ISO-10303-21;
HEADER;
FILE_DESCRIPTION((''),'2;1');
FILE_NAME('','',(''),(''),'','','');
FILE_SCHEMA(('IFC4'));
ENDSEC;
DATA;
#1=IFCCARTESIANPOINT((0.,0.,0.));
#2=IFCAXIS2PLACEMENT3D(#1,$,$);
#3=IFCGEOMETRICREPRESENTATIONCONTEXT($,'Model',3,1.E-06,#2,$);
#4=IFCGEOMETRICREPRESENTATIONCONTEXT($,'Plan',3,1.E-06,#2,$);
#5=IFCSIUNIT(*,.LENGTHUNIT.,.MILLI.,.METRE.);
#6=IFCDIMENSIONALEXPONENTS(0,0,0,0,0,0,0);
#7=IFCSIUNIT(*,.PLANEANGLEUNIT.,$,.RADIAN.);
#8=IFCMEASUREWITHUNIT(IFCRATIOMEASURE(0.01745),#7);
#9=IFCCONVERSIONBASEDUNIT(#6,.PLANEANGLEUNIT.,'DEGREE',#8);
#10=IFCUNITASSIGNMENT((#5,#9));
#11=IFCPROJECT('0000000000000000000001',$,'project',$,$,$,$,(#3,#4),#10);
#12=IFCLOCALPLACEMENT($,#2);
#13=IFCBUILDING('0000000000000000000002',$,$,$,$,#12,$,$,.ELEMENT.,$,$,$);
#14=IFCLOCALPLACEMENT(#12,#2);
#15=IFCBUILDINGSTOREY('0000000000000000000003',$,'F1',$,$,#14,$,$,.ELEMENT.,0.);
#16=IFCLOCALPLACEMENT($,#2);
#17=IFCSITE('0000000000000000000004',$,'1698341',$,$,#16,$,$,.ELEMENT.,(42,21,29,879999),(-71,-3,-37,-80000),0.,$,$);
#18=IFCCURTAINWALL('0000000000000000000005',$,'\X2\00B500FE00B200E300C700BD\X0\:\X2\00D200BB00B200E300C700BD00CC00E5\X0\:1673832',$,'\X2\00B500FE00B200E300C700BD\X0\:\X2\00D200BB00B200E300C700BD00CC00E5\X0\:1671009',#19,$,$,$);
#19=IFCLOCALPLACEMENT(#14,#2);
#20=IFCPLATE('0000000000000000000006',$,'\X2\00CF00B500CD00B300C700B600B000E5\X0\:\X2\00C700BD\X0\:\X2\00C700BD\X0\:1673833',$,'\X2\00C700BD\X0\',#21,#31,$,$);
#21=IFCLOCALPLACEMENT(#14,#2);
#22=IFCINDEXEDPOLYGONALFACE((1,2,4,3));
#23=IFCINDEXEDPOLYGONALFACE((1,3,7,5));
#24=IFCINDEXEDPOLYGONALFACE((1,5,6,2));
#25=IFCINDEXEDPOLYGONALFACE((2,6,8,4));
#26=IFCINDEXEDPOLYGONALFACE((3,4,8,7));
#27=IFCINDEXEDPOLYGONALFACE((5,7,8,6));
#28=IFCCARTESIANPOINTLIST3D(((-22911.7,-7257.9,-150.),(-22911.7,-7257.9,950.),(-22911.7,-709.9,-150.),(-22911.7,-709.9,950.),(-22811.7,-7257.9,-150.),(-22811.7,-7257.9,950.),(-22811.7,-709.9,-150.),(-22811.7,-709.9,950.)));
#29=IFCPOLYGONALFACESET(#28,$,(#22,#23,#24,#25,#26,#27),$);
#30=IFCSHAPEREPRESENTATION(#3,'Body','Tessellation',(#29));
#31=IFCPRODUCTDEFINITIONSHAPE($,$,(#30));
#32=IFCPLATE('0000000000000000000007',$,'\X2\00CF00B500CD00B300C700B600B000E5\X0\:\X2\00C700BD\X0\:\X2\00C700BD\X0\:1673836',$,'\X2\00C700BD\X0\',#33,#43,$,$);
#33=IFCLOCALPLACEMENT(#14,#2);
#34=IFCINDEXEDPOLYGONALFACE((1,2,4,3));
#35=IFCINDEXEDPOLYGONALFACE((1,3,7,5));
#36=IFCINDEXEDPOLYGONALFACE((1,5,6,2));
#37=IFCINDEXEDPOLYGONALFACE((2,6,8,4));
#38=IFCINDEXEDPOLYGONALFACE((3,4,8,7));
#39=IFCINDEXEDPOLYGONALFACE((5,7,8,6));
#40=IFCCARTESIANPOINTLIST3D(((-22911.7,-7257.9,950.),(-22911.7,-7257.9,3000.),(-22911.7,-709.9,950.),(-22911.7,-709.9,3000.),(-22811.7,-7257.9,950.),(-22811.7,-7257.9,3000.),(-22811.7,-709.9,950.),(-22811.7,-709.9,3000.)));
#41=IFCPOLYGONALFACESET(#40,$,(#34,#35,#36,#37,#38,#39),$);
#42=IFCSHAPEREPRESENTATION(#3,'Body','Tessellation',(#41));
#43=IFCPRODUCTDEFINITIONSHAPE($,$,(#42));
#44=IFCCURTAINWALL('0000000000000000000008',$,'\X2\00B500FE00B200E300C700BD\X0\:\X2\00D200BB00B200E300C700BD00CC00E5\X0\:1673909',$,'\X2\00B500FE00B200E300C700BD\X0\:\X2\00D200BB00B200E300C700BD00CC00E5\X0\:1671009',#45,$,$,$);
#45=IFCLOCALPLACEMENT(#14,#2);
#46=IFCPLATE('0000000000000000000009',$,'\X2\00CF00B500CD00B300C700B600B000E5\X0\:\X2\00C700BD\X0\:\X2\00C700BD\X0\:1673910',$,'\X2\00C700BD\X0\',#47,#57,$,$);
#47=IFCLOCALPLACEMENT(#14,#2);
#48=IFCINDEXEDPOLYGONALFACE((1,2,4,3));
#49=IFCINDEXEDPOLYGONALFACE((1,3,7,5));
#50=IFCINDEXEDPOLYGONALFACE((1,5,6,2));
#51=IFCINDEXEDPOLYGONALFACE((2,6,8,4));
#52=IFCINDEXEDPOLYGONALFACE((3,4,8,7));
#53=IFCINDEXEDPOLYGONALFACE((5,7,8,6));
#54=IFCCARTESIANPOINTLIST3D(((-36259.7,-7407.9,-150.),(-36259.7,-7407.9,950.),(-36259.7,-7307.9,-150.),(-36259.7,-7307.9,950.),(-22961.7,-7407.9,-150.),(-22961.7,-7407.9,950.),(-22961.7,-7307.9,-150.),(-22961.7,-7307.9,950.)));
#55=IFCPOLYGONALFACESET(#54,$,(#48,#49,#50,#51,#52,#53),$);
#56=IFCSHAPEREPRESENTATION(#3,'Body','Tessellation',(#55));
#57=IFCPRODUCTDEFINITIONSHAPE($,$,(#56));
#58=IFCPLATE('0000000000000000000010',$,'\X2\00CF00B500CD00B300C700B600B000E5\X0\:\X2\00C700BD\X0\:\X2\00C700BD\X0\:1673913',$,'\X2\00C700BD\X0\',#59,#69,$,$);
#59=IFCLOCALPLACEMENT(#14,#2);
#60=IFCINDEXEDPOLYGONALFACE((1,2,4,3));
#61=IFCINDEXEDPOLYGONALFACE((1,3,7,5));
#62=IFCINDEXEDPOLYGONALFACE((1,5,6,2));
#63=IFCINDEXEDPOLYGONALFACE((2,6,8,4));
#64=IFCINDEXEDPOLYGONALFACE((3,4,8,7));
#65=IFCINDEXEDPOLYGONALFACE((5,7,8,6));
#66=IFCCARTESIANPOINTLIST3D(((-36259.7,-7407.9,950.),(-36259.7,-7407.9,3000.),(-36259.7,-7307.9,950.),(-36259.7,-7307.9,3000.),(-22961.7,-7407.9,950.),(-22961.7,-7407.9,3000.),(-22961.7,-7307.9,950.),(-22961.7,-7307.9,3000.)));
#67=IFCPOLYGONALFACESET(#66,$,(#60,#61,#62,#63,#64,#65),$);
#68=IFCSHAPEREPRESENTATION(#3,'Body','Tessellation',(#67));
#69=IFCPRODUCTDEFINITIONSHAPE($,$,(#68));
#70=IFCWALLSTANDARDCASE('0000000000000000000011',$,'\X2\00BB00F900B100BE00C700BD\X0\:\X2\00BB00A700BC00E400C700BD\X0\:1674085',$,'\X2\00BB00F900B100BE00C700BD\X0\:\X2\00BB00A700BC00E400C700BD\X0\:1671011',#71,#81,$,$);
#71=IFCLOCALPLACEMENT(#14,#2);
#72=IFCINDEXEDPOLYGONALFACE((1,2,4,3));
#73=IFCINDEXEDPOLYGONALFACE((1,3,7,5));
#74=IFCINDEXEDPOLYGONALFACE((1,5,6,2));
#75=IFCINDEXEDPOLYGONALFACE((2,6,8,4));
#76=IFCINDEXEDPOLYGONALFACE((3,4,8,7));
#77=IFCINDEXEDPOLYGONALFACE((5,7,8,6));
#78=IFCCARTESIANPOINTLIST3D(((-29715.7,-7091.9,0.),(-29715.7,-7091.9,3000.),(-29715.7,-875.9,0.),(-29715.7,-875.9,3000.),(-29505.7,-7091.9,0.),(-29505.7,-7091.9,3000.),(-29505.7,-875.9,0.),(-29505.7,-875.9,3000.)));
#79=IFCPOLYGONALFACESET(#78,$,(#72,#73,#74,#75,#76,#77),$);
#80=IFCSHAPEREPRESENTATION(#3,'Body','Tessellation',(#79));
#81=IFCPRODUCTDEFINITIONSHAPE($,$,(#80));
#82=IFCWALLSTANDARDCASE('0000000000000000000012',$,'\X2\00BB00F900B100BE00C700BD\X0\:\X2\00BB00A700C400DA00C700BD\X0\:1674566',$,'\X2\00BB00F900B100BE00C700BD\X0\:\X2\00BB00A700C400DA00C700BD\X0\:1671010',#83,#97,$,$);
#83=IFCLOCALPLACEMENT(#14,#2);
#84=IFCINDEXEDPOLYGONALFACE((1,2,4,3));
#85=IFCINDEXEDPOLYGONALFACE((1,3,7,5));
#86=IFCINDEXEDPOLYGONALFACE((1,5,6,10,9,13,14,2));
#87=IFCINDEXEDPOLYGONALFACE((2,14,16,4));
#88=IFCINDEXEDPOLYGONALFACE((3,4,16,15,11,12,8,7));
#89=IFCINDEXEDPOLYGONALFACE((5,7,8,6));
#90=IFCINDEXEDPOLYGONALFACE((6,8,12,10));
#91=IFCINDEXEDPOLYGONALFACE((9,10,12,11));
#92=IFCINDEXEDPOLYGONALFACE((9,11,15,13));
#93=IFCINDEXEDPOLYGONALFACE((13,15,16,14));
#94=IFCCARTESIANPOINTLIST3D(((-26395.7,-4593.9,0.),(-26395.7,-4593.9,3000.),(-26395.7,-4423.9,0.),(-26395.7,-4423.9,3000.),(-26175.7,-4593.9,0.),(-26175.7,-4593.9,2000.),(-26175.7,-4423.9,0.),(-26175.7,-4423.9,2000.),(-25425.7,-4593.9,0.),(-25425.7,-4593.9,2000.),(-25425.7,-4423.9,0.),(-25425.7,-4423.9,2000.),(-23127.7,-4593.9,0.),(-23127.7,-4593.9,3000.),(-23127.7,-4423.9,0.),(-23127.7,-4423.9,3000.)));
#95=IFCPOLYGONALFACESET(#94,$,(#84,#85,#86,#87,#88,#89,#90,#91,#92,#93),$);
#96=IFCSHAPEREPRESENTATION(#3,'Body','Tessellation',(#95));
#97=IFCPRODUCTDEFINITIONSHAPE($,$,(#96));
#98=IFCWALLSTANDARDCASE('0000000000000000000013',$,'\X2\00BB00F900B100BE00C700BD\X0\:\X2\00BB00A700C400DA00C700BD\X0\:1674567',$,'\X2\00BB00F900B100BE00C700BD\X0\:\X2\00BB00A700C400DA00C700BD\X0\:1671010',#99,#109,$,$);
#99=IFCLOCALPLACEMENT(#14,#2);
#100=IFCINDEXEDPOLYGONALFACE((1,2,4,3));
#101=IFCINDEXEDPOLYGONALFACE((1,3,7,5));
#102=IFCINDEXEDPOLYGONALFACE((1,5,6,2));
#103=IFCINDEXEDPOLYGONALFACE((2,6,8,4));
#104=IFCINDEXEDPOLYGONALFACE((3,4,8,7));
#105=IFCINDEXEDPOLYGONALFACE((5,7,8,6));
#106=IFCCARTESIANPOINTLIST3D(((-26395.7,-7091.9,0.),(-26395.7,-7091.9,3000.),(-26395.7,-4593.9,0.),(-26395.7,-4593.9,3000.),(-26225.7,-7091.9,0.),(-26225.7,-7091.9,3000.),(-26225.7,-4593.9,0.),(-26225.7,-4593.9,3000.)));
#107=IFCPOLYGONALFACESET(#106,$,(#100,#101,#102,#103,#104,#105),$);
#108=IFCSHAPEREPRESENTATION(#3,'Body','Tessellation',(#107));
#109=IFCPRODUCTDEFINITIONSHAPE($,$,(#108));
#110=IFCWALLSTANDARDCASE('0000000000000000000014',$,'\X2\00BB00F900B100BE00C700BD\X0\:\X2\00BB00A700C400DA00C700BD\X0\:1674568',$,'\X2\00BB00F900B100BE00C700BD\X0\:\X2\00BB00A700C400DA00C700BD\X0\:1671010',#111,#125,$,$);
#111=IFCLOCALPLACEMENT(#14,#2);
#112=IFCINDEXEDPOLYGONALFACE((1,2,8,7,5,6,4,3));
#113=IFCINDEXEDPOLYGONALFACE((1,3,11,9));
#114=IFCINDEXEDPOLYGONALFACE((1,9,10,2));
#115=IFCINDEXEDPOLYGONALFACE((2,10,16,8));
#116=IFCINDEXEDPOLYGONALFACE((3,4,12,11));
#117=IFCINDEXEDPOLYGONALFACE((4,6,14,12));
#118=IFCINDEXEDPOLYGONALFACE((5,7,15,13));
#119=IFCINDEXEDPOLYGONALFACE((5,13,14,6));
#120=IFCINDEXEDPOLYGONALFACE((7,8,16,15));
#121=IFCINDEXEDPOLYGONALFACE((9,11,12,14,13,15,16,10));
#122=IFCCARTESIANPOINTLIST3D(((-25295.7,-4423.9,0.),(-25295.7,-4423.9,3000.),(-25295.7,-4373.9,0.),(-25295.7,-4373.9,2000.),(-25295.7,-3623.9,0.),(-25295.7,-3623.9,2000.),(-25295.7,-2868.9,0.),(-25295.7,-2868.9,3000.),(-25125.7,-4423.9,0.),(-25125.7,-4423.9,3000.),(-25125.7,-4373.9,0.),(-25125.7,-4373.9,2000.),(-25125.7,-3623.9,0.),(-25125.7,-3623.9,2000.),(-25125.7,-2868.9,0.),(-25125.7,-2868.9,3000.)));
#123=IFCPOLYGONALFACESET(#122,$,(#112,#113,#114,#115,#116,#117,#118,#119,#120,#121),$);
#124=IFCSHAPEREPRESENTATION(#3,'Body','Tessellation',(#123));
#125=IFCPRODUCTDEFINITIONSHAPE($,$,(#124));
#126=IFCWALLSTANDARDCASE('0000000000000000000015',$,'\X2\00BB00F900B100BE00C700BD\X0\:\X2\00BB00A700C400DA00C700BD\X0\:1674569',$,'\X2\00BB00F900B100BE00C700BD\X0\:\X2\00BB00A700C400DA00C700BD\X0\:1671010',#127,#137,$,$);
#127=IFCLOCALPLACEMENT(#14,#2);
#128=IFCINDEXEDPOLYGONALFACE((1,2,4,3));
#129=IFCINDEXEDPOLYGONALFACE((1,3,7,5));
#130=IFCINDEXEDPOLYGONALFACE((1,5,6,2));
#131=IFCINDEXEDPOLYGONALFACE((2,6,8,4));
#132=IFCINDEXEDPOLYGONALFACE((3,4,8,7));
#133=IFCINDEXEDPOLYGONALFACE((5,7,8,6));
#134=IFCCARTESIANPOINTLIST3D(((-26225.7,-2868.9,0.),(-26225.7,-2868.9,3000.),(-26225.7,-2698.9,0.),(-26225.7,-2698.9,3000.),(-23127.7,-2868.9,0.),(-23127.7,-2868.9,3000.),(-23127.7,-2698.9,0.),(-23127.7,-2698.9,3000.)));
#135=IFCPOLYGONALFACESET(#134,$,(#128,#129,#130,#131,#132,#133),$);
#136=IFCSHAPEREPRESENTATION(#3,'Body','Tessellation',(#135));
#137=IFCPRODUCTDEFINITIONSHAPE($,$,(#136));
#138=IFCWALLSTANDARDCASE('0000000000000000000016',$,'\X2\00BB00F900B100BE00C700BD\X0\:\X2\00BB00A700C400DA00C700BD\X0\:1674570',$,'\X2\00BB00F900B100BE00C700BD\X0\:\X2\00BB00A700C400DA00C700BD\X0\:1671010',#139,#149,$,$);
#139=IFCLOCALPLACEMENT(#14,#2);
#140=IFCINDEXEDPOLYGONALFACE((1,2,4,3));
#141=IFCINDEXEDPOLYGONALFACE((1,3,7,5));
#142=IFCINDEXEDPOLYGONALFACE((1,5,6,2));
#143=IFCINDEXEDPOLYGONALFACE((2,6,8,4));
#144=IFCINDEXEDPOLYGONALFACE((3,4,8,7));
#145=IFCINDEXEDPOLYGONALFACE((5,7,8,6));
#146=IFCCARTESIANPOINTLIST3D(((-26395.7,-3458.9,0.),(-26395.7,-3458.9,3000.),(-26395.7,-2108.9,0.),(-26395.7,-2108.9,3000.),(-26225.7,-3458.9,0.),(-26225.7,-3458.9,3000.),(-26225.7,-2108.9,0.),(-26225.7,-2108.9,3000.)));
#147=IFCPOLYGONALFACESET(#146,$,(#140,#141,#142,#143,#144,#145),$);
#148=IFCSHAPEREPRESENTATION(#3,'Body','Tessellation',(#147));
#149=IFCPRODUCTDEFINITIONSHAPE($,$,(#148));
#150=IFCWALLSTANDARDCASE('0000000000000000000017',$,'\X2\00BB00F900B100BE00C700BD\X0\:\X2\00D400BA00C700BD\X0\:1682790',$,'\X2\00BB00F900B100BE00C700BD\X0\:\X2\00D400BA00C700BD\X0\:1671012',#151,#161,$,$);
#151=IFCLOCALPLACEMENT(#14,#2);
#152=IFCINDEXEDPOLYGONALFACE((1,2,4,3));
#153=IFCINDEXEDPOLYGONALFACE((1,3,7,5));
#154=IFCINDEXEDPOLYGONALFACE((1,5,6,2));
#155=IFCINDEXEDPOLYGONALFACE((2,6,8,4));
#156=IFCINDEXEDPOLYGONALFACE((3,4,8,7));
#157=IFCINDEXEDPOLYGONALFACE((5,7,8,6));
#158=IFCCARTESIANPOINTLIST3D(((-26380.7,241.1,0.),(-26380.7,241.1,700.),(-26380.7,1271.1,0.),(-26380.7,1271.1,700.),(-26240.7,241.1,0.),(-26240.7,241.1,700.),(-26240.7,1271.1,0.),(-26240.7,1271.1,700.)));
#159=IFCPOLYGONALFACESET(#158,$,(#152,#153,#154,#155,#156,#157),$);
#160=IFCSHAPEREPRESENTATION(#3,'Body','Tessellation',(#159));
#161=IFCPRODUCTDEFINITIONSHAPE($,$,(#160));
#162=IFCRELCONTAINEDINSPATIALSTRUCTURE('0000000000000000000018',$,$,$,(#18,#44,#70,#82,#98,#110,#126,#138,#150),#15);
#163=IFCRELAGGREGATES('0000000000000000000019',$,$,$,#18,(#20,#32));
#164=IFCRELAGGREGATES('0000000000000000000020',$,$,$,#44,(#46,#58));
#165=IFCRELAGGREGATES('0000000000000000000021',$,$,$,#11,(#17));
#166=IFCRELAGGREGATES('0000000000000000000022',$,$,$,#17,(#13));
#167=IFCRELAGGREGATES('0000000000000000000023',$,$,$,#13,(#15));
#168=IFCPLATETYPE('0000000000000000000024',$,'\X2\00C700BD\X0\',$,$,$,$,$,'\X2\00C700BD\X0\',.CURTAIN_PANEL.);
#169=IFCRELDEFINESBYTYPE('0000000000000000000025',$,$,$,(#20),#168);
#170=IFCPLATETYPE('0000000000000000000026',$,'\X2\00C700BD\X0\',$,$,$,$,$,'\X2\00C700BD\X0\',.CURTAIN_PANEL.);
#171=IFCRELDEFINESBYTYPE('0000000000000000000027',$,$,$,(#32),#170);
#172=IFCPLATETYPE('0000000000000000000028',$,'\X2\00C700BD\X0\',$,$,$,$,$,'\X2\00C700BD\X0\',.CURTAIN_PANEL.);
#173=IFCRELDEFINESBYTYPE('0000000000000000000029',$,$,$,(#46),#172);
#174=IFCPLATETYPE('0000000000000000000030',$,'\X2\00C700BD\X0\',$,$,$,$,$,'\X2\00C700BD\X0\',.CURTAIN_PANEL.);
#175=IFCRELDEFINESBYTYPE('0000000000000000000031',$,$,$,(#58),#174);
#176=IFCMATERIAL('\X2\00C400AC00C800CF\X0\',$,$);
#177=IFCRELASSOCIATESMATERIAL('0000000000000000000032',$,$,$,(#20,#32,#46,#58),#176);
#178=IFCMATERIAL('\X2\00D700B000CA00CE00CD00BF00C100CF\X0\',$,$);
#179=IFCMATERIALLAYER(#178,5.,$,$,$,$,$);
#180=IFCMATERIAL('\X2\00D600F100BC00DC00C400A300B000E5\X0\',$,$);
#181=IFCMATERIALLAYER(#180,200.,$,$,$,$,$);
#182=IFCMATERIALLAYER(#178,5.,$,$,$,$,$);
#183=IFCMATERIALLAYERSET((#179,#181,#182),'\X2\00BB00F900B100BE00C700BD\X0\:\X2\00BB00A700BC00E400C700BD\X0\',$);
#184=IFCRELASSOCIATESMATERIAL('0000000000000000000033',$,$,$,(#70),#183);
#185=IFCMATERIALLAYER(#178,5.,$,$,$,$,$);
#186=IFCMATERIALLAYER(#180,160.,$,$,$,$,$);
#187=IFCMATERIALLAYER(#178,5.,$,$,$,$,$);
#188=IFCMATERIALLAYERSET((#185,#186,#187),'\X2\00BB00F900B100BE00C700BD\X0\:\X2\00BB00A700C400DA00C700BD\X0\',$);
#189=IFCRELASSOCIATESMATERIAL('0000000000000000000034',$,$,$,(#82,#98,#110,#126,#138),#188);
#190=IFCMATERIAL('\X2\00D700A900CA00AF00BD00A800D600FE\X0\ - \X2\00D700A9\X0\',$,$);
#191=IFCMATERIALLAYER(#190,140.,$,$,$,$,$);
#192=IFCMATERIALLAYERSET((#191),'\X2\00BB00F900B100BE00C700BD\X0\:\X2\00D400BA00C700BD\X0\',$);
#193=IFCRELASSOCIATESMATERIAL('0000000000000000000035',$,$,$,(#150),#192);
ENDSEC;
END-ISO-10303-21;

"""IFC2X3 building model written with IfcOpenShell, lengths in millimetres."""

from ifc_helpers import new_model, entity, si_unit, converted_unit, frame, frame_2d, origin, origin_2d_with_axis, place, context, project, spatial, rectangle, extrude, source, transform, mapped, material, layer, layer_set, layer_usage, type_object, type_shapes, element, aggregate, save


model = new_model("IFC2X3")

# Units and contexts
model_context = context("Model", 3, precision=1e-06, world=origin())
plan_context = context("Plan", 3, precision=1e-06, world=origin())
ifc_project = project(units=[si_unit("LENGTHUNIT", "METRE", prefix="MILLI"), converted_unit("PLANEANGLEUNIT", "DEGREE", entity("IfcRatioMeasure", 0.01745), si_unit("PLANEANGLEUNIT", "RADIAN"), dimensions=[0, 0, 0, 0, 0, 0, 0])], contexts=[model_context, plan_context])

# Site, building, storey
site_placement = place(None, origin())
site = spatial("IfcSite", under=ifc_project, at=site_placement, Name="1698341", CompositionType="ELEMENT", RefLatitude=(42, 21, 29, 879999), RefLongitude=(-71, -3, -37, -80000), RefElevation=0.0)
building_placement = place(None, origin())
building = spatial("IfcBuilding", under=site, at=building_placement, CompositionType="ELEMENT")
storey_placement = place(building_placement, origin())
storey = spatial("IfcBuildingStorey", under=building, at=storey_placement, Name="F1", CompositionType="ELEMENT", Elevation=0.0)

# Curtain walls, plates
curtain_wall_1_placement = place(storey_placement, origin())
curtain_wall_1 = element("IfcCurtainWall", 1, at=curtain_wall_1_placement, inside=storey, Name="µþ²ãÇ½:Ò»²ãÇ½Ìå:1673832", ObjectType="µþ²ãÇ½:Ò»²ãÇ½Ìå:1671009")
ifc_material_1 = material(Name="Ä¬ÈÏ")
plate_type_1 = type_object("IfcPlateType", Name="Ç½", ElementType="Ç½", PredefinedType="CURTAIN_PANEL")
shared_shape_1 = source(origin(), model_context, "Body", "SweptSolid", [
    extrude(rectangle(XDim=100.0, YDim=6548.0, at=origin_2d_with_axis()), frame((0.0, 100.0, 0.0), z_axis=(0.0, 0.0, 1.0), x_axis=(0.0, 1.0, 0.0)), (0.0, 0.0, 1.0), 1100.0),
])
type_shapes(plate_type_1, [shared_shape_1])
plate_1_placement = place(None, frame((-22961.7, -3983.9, -150.0), z_axis=(0.0, 0.0, 1.0), x_axis=(0.0, -1.0, 0.0)))
plate_1 = element("IfcPlate", 2, at=plate_1_placement, type_object=plate_type_1, material=ifc_material_1, Name="ÏµÍ³Ç¶°å:Ç½:Ç½:1673833", ObjectType="Ç½", context=model_context, shape_type="MappedRepresentation", body=[
    mapped(shared_shape_1, transform((0.0, 0.0, 0.0), scale=1.0)),
])
plate_type_2 = type_object("IfcPlateType", Name="Ç½", ElementType="Ç½", PredefinedType="CURTAIN_PANEL")
shared_shape_2 = source(origin(), model_context, "Body", "SweptSolid", [
    extrude(rectangle(XDim=100.0, YDim=6548.0, at=origin_2d_with_axis()), frame((0.0, 100.0, 0.0), z_axis=(0.0, 0.0, 1.0), x_axis=(0.0, 1.0, 0.0)), (0.0, 0.0, 1.0), 2050.0),
])
type_shapes(plate_type_2, [shared_shape_2])
plate_2_placement = place(None, frame((-22961.7, -3983.9, 950.0), z_axis=(0.0, 0.0, 1.0), x_axis=(0.0, -1.0, 0.0)))
plate_2 = element("IfcPlate", 3, at=plate_2_placement, type_object=plate_type_2, material=ifc_material_1, Name="ÏµÍ³Ç¶°å:Ç½:Ç½:1673836", ObjectType="Ç½", context=model_context, shape_type="MappedRepresentation", body=[
    mapped(shared_shape_2, transform((0.0, 0.0, 0.0), scale=1.0)),
])
aggregate(curtain_wall_1, [plate_1, plate_2])
curtain_wall_2_placement = place(storey_placement, origin())
curtain_wall_2 = element("IfcCurtainWall", 4, at=curtain_wall_2_placement, inside=storey, Name="µþ²ãÇ½:Ò»²ãÇ½Ìå:1673909", ObjectType="µþ²ãÇ½:Ò»²ãÇ½Ìå:1671009")
plate_type_3 = type_object("IfcPlateType", Name="Ç½", ElementType="Ç½", PredefinedType="CURTAIN_PANEL")
shared_shape_3 = source(origin(), model_context, "Body", "SweptSolid", [
    extrude(rectangle(XDim=100.0, YDim=13298.0, at=origin_2d_with_axis()), frame((0.0, 100.0, 0.0), z_axis=(0.0, 0.0, 1.0), x_axis=(0.0, 1.0, 0.0)), (0.0, 0.0, 1.0), 1100.0),
])
type_shapes(plate_type_3, [shared_shape_3])
plate_3_placement = place(None, frame((-29610.7, -7257.9, -150.0), z_axis=(0.0, 0.0, 1.0), x_axis=(-1.0, 0.0, 0.0)))
plate_3 = element("IfcPlate", 5, at=plate_3_placement, type_object=plate_type_3, material=ifc_material_1, Name="ÏµÍ³Ç¶°å:Ç½:Ç½:1673910", ObjectType="Ç½", context=model_context, shape_type="MappedRepresentation", body=[
    mapped(shared_shape_3, transform((0.0, 0.0, 0.0), scale=1.0)),
])
plate_type_4 = type_object("IfcPlateType", Name="Ç½", ElementType="Ç½", PredefinedType="CURTAIN_PANEL")
shared_shape_4 = source(origin(), model_context, "Body", "SweptSolid", [
    extrude(rectangle(XDim=100.0, YDim=13298.0, at=origin_2d_with_axis()), frame((0.0, 100.0, 0.0), z_axis=(0.0, 0.0, 1.0), x_axis=(0.0, 1.0, 0.0)), (0.0, 0.0, 1.0), 2050.0),
])
type_shapes(plate_type_4, [shared_shape_4])
plate_4_placement = place(None, frame((-29610.7, -7257.9, 950.0), z_axis=(0.0, 0.0, 1.0), x_axis=(-1.0, 0.0, 0.0)))
plate_4 = element("IfcPlate", 6, at=plate_4_placement, type_object=plate_type_4, material=ifc_material_1, Name="ÏµÍ³Ç¶°å:Ç½:Ç½:1673913", ObjectType="Ç½", context=model_context, shape_type="MappedRepresentation", body=[
    mapped(shared_shape_4, transform((0.0, 0.0, 0.0), scale=1.0)),
])
aggregate(curtain_wall_2, [plate_3, plate_4])

# Shared definitions
ifc_material_2 = material(Name="Öñ¼ÜÄ£°å")
ifc_material_3 = material(Name="×°ÊÎÍ¿ÁÏ")

# Wall
ifc_layer_1 = layer(ifc_material_3, 5.0)
ifc_layer_2 = layer(ifc_material_2, 200.0)
ifc_layer_3 = layer(ifc_material_3, 5.0)
ifc_layer_set_1 = layer_set([ifc_layer_1, ifc_layer_2, ifc_layer_3], Name="»ù±¾Ç½:»§¼äÇ½")
ifc_layer_usage_1 = layer_usage(ifc_layer_set_1, "AXIS2", "NEGATIVE", 105.0)
wall_1_placement = place(storey_placement, frame((-29610.7, -7091.9, 0.0), z_axis=(0.0, 0.0, 1.0), x_axis=(0.0, 1.0, 0.0)))
element("IfcWallStandardCase", 7, at=wall_1_placement, inside=storey, material=ifc_layer_usage_1, Name="»ù±¾Ç½:»§¼äÇ½:1674085", ObjectType="»ù±¾Ç½:»§¼äÇ½:1671011", context=model_context, shape_type="SweptSolid", body=[
    extrude(rectangle(XDim=6216.0, YDim=210.0, at=frame_2d((3108.0, 0.0), x_axis=(-1.0, 0.0))), origin(), (0.0, 0.0, 1.0), 3000.0),
])

# Wall, opening
ifc_layer_4 = layer(ifc_material_3, 5.0)
ifc_layer_5 = layer(ifc_material_2, 160.0)
ifc_layer_6 = layer(ifc_material_3, 5.0)
ifc_layer_set_2 = layer_set([ifc_layer_4, ifc_layer_5, ifc_layer_6], Name="»ù±¾Ç½:»§ÄÚÇ½")
ifc_layer_usage_2 = layer_usage(ifc_layer_set_2, "AXIS2", "POSITIVE", -85.0)
wall_2_placement = place(storey_placement, frame((-23127.7, -4508.9, 0.0), z_axis=(0.0, 0.0, 1.0), x_axis=(-1.0, 0.0, 0.0)))
wall_2 = element("IfcWallStandardCase", 8, at=wall_2_placement, inside=storey, material=ifc_layer_usage_2, Name="»ù±¾Ç½:»§ÄÚÇ½:1674566", ObjectType="»ù±¾Ç½:»§ÄÚÇ½:1671010", context=model_context, shape_type="SweptSolid", body=[
    extrude(rectangle(XDim=3268.0, YDim=170.0, at=frame_2d((1634.0, 0.0), x_axis=(-1.0, 0.0))), origin(), (0.0, 0.0, 1.0), 3000.0),
])
opening_1_placement = place(wall_2_placement, frame((2298.0, -85.0, 0.0)))
element("IfcOpeningElement", 9, at=opening_1_placement, cuts=wall_2, ObjectType="Opening", context=model_context, shape_type="SweptSolid", body=[
    extrude(rectangle(XDim=750.0, YDim=2000.0, at=frame_2d((1000.0, 375.0), x_axis=(0.0, 1.0))), frame((0.0, 0.0, 0.0), z_axis=(0.0, 1.0, 0.0), x_axis=(0.0, 0.0, 1.0)), (0.0, 0.0, 1.0), 170.0),
])

# Wall
ifc_layer_usage_3 = layer_usage(ifc_layer_set_2, "AXIS2", "POSITIVE", -85.0)
wall_3_placement = place(storey_placement, frame((-26310.7, -4593.9, 0.0), z_axis=(0.0, 0.0, 1.0), x_axis=(0.0, -1.0, 0.0)))
element("IfcWallStandardCase", 10, at=wall_3_placement, inside=storey, material=ifc_layer_usage_3, Name="»ù±¾Ç½:»§ÄÚÇ½:1674567", ObjectType="»ù±¾Ç½:»§ÄÚÇ½:1671010", context=model_context, shape_type="SweptSolid", body=[
    extrude(rectangle(XDim=2498.0, YDim=170.0, at=frame_2d((1249.0, 0.0), x_axis=(-1.0, 0.0))), origin(), (0.0, 0.0, 1.0), 3000.0),
])

# Wall, opening
ifc_layer_usage_4 = layer_usage(ifc_layer_set_2, "AXIS2", "POSITIVE", -85.0)
wall_4_placement = place(storey_placement, frame((-25210.7, -4423.9, 0.0), z_axis=(0.0, 0.0, 1.0), x_axis=(0.0, 1.0, 0.0)))
wall_4 = element("IfcWallStandardCase", 11, at=wall_4_placement, inside=storey, material=ifc_layer_usage_4, Name="»ù±¾Ç½:»§ÄÚÇ½:1674568", ObjectType="»ù±¾Ç½:»§ÄÚÇ½:1671010", context=model_context, shape_type="SweptSolid", body=[
    extrude(rectangle(XDim=1555.0, YDim=170.0, at=frame_2d((777.5, 0.0), x_axis=(-1.0, 0.0))), origin(), (0.0, 0.0, 1.0), 3000.0),
])
opening_2_placement = place(wall_4_placement, frame((800.0, 85.0, 0.0)))
element("IfcOpeningElement", 12, at=opening_2_placement, cuts=wall_4, ObjectType="Opening", context=model_context, shape_type="SweptSolid", body=[
    extrude(rectangle(XDim=750.0, YDim=2000.0, at=frame_2d((1000.0, 375.0), x_axis=(0.0, 1.0))), frame((0.0, 0.0, 0.0), z_axis=(0.0, -1.0, 0.0), x_axis=(0.0, 0.0, 1.0)), (0.0, 0.0, 1.0), 170.0),
])

# Walls
ifc_layer_usage_5 = layer_usage(ifc_layer_set_2, "AXIS2", "POSITIVE", -85.0)
wall_5_placement = place(storey_placement, frame((-26225.7, -2783.9, 0.0)))
element("IfcWallStandardCase", 13, at=wall_5_placement, inside=storey, material=ifc_layer_usage_5, Name="»ù±¾Ç½:»§ÄÚÇ½:1674569", ObjectType="»ù±¾Ç½:»§ÄÚÇ½:1671010", context=model_context, shape_type="SweptSolid", body=[
    extrude(rectangle(XDim=3098.0, YDim=170.0, at=frame_2d((1549.0, 0.0), x_axis=(-1.0, 0.0))), origin(), (0.0, 0.0, 1.0), 3000.0),
])
ifc_layer_usage_6 = layer_usage(ifc_layer_set_2, "AXIS2", "POSITIVE", -85.0)
wall_6_placement = place(storey_placement, frame((-26310.7, -3458.9, 0.0), z_axis=(0.0, 0.0, 1.0), x_axis=(0.0, 1.0, 0.0)))
element("IfcWallStandardCase", 14, at=wall_6_placement, inside=storey, material=ifc_layer_usage_6, Name="»ù±¾Ç½:»§ÄÚÇ½:1674570", ObjectType="»ù±¾Ç½:»§ÄÚÇ½:1671010", context=model_context, shape_type="SweptSolid", body=[
    extrude(rectangle(XDim=1350.0, YDim=170.0, at=frame_2d((675.0, 0.0), x_axis=(-1.0, 0.0))), origin(), (0.0, 0.0, 1.0), 3000.0),
])
ifc_material_4 = material(Name="×©Ê¯½¨Öþ - ×©")
ifc_layer_7 = layer(ifc_material_4, 140.0)
ifc_layer_set_3 = layer_set([ifc_layer_7], Name="»ù±¾Ç½:ÔºÇ½")
ifc_layer_usage_7 = layer_usage(ifc_layer_set_3, "AXIS2", "NEGATIVE", 70.0)
wall_7_placement = place(storey_placement, frame((-26310.7, 1271.1, 0.0), z_axis=(0.0, 0.0, 1.0), x_axis=(0.0, -1.0, 0.0)))
element("IfcWallStandardCase", 15, at=wall_7_placement, inside=storey, material=ifc_layer_usage_7, Name="»ù±¾Ç½:ÔºÇ½:1682790", ObjectType="»ù±¾Ç½:ÔºÇ½:1671012", context=model_context, shape_type="SweptSolid", body=[
    extrude(rectangle(XDim=1030.0, YDim=140.0, at=frame_2d((515.0, 0.0), x_axis=(-1.0, 0.0))), origin(), (0.0, 0.0, 1.0), 700.0),
])

save(model, "model.ifc")
